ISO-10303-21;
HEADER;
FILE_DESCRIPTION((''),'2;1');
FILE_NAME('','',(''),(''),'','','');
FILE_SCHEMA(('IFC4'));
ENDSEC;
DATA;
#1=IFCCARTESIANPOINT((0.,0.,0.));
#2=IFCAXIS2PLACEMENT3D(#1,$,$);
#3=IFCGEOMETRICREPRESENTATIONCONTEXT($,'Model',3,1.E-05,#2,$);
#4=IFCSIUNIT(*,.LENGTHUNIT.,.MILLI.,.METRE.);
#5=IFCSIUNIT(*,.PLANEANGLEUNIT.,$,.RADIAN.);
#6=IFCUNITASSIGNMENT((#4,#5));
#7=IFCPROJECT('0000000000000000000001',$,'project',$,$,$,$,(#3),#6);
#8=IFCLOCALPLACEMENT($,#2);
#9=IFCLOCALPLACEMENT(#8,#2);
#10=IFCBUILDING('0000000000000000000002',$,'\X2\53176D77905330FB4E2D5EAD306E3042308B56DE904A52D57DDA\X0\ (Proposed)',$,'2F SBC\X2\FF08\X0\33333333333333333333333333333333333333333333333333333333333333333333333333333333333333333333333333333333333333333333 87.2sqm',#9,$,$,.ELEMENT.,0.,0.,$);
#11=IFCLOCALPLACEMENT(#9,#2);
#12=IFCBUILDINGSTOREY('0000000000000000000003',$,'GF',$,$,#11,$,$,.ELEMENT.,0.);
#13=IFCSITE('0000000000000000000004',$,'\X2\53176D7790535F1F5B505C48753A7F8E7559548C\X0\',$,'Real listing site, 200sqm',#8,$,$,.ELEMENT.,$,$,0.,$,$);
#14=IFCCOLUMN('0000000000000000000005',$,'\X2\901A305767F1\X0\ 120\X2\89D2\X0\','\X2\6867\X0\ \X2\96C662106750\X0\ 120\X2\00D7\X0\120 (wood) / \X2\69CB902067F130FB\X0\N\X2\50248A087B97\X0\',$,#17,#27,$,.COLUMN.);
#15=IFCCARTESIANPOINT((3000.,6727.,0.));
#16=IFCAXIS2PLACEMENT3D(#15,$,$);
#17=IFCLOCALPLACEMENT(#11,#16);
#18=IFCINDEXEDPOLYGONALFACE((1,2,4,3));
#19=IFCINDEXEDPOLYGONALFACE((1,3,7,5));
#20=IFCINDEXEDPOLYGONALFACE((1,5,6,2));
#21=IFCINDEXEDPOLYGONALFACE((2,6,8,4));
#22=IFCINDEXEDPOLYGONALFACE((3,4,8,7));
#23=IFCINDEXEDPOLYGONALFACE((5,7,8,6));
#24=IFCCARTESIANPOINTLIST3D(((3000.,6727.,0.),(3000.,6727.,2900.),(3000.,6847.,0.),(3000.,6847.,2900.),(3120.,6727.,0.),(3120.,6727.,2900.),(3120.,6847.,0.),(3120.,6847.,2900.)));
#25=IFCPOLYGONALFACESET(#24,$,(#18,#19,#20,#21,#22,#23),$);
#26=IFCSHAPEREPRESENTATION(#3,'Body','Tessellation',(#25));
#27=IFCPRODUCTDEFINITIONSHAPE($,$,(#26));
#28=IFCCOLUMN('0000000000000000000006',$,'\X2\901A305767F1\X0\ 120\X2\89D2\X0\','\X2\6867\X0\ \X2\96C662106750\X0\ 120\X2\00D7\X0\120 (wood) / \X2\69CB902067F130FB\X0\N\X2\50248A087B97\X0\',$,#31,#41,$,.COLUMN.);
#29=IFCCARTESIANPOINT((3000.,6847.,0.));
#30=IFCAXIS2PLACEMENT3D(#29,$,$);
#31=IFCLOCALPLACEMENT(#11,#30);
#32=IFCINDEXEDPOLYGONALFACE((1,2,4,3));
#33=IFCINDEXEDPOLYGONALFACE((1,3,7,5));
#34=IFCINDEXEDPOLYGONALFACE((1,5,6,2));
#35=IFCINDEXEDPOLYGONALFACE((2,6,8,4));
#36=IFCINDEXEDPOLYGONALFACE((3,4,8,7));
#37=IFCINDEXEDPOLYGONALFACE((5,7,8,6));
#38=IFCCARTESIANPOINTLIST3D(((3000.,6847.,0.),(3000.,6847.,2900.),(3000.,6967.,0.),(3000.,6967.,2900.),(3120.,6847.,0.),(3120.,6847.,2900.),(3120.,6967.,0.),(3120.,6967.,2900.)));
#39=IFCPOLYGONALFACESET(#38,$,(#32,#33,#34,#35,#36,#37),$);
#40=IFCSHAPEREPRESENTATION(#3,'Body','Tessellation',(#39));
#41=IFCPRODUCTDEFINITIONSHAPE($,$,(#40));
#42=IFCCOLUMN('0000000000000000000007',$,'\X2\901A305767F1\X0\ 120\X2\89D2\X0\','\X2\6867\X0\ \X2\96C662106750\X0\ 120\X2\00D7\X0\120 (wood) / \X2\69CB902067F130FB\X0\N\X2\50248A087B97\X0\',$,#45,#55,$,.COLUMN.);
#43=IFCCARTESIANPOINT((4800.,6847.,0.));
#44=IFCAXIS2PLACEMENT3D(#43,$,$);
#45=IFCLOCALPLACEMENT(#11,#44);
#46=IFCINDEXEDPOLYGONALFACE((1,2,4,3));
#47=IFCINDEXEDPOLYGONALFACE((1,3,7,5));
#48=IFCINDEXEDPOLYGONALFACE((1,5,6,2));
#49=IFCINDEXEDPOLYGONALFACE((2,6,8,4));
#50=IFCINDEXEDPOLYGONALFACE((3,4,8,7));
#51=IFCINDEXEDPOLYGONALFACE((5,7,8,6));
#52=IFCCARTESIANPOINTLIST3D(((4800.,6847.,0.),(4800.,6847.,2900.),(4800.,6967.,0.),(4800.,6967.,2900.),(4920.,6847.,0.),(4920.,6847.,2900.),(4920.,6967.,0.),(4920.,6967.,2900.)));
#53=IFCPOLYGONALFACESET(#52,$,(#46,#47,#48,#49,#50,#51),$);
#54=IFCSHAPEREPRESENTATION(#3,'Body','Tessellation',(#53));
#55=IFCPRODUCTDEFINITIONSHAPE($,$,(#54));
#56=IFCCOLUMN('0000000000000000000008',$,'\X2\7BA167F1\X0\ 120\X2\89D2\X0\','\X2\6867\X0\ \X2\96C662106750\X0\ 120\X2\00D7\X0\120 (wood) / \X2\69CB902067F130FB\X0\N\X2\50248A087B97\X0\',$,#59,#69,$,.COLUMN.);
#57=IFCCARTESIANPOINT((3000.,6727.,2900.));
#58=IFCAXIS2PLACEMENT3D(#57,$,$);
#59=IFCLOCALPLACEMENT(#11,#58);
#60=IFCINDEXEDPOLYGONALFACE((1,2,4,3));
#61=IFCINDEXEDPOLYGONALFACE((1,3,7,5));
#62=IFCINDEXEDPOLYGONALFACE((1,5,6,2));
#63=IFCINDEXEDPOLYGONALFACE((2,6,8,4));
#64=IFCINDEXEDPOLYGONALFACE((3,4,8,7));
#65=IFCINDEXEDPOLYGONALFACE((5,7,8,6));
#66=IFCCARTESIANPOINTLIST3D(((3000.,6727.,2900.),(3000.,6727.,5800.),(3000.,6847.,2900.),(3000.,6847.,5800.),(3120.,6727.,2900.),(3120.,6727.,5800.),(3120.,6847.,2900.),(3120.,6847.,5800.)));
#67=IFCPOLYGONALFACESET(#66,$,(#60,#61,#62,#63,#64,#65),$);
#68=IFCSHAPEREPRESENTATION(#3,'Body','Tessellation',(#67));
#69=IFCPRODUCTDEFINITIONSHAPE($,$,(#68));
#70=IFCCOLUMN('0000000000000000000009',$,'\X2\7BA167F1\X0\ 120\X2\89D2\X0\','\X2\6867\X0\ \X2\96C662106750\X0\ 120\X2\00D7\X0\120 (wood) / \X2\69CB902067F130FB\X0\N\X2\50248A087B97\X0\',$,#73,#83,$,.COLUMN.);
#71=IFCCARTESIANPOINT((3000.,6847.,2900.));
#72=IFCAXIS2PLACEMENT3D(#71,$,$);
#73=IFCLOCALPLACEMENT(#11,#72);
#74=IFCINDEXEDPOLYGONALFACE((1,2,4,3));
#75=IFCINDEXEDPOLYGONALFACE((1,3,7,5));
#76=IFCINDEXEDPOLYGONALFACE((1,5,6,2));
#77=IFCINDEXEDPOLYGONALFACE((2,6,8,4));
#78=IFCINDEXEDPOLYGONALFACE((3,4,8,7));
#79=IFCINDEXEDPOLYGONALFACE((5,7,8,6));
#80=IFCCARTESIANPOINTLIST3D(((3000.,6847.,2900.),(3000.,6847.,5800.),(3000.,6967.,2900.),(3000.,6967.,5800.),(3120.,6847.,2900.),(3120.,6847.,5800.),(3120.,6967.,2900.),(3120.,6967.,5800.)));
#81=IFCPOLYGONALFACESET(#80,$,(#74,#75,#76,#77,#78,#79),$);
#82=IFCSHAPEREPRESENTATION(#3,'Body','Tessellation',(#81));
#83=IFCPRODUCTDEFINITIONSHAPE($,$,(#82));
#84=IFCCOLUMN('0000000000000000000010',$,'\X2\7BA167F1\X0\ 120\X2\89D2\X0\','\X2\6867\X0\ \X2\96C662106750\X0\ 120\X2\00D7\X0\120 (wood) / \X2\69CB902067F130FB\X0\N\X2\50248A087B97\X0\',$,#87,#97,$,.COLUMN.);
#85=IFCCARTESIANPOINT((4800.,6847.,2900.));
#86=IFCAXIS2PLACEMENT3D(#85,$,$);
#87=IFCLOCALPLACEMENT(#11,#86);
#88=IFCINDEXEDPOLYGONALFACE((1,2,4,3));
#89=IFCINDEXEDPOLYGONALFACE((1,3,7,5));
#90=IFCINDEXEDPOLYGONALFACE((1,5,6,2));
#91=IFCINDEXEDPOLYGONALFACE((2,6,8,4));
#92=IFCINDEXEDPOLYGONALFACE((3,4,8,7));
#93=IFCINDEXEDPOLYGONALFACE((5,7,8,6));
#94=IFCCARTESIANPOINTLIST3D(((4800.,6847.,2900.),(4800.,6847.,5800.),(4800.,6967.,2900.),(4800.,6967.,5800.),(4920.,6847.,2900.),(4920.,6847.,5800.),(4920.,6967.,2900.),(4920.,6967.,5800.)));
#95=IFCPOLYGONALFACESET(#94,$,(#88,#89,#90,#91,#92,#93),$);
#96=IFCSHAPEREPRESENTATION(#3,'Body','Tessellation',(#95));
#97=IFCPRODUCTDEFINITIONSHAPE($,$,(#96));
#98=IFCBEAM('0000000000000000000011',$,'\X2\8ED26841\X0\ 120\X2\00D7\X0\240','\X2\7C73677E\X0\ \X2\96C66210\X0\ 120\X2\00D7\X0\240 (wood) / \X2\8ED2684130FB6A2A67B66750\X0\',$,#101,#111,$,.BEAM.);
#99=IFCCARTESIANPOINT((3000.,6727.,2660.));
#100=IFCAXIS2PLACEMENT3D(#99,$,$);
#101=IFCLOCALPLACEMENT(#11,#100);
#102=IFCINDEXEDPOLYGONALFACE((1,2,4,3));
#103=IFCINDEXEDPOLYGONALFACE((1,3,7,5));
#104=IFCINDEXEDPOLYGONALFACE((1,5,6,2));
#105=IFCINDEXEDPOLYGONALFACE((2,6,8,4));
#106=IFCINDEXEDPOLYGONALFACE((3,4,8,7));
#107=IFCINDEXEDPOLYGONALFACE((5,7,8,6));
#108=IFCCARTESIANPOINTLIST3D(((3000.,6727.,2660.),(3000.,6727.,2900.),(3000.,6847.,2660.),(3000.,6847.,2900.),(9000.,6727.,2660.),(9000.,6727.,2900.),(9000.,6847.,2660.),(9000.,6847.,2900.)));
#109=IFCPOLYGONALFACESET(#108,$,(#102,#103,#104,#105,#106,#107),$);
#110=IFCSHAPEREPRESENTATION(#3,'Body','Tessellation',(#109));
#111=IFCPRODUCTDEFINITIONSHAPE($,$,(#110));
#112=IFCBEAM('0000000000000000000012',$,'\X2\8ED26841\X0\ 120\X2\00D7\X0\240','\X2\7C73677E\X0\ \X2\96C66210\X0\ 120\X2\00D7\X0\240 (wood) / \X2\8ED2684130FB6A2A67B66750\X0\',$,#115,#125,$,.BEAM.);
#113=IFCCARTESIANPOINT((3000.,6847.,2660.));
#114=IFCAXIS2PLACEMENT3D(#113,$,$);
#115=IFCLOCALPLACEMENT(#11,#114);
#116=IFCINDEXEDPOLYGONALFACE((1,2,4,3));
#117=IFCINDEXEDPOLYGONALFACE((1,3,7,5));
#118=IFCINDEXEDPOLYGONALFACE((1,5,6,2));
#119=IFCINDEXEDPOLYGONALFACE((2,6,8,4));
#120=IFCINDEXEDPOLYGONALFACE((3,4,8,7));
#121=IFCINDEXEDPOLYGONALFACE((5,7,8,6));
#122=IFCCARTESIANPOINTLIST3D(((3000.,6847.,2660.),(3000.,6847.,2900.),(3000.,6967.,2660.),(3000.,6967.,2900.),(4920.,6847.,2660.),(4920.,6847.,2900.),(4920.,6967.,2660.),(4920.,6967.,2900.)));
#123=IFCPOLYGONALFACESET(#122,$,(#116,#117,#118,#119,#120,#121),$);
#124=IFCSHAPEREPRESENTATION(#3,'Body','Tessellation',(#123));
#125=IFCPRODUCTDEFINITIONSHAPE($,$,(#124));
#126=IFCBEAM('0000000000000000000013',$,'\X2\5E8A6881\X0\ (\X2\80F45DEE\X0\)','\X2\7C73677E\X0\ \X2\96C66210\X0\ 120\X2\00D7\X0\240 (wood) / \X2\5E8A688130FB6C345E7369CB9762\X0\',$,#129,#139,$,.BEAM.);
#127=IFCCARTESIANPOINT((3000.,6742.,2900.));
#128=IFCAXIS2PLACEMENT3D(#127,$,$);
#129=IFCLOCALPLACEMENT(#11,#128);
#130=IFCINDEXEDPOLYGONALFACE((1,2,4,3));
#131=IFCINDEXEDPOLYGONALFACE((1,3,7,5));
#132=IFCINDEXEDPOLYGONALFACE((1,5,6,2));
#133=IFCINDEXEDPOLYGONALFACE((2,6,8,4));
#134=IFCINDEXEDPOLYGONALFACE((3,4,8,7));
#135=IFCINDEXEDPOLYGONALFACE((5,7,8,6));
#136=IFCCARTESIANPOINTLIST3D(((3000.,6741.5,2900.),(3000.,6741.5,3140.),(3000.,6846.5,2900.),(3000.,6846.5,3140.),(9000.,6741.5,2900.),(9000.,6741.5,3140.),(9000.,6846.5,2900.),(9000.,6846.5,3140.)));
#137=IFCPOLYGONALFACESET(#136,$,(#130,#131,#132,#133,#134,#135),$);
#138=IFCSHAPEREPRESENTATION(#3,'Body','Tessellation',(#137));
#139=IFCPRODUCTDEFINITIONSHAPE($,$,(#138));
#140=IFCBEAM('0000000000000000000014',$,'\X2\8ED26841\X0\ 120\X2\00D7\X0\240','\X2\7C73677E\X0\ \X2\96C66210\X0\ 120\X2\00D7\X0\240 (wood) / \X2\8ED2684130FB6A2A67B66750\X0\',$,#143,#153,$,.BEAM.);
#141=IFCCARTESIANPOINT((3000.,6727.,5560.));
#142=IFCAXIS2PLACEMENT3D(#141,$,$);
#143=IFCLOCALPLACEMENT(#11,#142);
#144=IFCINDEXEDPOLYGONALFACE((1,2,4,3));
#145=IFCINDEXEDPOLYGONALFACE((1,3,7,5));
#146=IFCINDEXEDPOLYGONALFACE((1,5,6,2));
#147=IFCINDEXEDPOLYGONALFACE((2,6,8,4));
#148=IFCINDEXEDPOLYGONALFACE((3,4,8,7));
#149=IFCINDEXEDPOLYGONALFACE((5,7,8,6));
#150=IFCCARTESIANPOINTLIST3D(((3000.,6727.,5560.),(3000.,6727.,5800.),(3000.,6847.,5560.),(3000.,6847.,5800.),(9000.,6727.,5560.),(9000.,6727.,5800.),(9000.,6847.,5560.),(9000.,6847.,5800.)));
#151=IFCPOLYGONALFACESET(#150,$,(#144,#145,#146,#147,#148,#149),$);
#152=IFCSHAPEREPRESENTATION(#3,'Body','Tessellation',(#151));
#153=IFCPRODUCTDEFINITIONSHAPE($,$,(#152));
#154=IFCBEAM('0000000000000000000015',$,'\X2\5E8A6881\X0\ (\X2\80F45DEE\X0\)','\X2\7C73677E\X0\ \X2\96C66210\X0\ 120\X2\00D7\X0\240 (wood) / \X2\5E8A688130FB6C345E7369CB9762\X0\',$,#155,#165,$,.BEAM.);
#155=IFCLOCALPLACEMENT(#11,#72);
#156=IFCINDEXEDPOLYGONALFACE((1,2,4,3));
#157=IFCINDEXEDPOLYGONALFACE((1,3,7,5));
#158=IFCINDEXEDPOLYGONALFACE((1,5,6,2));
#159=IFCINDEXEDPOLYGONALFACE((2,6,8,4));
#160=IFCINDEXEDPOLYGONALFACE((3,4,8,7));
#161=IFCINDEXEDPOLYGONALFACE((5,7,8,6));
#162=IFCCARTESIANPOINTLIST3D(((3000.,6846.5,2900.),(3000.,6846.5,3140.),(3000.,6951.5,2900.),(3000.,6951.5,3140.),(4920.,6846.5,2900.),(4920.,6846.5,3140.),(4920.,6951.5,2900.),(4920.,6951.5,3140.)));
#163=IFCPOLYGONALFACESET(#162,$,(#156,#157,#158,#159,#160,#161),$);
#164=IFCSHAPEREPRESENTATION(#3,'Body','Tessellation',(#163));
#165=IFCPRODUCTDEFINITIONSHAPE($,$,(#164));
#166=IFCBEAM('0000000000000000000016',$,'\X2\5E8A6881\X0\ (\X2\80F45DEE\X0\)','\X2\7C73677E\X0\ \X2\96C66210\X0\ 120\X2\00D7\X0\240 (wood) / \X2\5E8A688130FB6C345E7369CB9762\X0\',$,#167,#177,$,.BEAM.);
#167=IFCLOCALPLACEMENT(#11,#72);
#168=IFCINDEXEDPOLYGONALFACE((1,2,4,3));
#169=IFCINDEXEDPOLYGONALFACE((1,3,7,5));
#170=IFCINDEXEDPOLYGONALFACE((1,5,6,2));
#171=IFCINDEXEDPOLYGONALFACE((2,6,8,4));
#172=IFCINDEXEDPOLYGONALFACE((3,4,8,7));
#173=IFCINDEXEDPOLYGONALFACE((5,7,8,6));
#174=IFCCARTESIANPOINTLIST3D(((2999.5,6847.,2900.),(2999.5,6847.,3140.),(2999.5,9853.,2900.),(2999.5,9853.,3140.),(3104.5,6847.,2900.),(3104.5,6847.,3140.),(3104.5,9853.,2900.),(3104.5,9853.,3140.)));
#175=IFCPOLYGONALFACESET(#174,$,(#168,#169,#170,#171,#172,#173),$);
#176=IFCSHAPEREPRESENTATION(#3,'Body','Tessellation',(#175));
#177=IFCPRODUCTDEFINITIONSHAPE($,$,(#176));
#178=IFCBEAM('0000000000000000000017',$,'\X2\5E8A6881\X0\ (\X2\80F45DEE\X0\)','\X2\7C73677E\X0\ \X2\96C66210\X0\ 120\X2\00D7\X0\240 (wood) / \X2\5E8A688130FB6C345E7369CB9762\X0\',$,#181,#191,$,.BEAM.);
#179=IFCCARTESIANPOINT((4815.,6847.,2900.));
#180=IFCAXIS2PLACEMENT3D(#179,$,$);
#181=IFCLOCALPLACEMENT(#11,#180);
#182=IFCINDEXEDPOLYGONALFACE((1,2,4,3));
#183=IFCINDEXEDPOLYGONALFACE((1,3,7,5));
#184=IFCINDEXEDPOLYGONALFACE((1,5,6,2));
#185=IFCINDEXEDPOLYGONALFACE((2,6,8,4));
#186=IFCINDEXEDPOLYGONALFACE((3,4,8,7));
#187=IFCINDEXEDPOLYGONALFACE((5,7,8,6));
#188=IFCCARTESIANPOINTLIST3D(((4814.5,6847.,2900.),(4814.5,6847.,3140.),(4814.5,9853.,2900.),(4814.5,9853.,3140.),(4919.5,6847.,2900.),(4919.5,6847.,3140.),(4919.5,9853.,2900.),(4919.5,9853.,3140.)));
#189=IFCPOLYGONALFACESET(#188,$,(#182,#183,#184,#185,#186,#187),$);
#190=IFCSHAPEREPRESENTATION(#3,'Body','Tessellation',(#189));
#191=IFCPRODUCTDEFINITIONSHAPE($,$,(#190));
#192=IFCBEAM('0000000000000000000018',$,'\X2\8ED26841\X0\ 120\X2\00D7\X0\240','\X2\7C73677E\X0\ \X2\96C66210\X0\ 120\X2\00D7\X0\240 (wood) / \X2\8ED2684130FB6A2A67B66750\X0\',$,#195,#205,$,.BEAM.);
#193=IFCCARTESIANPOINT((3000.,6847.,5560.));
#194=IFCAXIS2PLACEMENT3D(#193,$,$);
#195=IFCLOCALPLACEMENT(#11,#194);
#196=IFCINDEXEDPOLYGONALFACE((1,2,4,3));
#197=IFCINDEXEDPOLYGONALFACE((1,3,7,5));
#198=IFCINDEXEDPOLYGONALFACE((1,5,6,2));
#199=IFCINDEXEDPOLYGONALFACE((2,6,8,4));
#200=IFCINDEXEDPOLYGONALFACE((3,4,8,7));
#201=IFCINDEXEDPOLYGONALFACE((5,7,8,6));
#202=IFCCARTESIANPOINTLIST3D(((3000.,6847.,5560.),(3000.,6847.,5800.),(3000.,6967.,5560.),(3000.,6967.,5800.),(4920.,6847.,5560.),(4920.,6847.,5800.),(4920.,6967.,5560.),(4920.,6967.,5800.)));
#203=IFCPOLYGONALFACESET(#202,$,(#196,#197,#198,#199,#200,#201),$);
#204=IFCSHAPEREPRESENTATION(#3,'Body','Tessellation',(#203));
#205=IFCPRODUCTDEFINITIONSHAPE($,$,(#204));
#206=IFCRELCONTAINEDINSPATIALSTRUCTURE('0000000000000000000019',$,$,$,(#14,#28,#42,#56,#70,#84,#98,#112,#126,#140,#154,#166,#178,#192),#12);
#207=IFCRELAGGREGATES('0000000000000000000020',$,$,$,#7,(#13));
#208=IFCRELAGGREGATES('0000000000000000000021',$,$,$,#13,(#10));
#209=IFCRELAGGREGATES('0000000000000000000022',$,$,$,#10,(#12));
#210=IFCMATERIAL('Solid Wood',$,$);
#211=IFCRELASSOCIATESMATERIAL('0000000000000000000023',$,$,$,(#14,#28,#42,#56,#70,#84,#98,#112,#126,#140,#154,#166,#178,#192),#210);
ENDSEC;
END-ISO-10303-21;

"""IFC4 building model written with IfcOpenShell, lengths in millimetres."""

from ifc_helpers import new_model, si_unit, frame, frame_2d, origin, place, context, project, spatial, rectangle, extrude, material, element, save


model = new_model("IFC4")

# Units and contexts
model_context = context("Model", 3, precision=1e-05, world=origin())
ifc_project = project(units=[si_unit("LENGTHUNIT", "METRE", prefix="MILLI"), si_unit("PLANEANGLEUNIT", "RADIAN")], contexts=[model_context])

# Site, building, storey
site_placement = place(None, origin())
site = spatial("IfcSite", under=ifc_project, at=site_placement, Name="北海道弟子屈町美留和", ObjectType="Real listing site, 200sqm", CompositionType="ELEMENT", RefElevation=0.0)
building_placement = place(site_placement, origin())
building = spatial("IfcBuilding", under=site, at=building_placement, Name="北海道・中庭のある回遊動線 (Proposed)", ObjectType="2F SBC（33333333333333333333333333333333333333333333333333333333333333333333333333333333333333333333333333333333333333333333 87.2sqm", CompositionType="ELEMENT", ElevationOfRefHeight=0.0, ElevationOfTerrain=0.0)
storey_placement = place(building_placement, origin())
storey = spatial("IfcBuildingStorey", under=building, at=storey_placement, Name="GF", CompositionType="ELEMENT", Elevation=0.0)

# Columns
ifc_material_1 = material(Name="Solid Wood")
column_1_placement = place(storey_placement, frame((3000.0, 6727.0, 0.0)))
element("IfcColumn", 1, at=column_1_placement, inside=storey, material=ifc_material_1, Name="通し柱 120角", Description="桧 集成材 120×120 (wood) / 構造柱・N値計算", PredefinedType="COLUMN", context=model_context, shape_type="SweptSolid", body=[
    extrude(rectangle(XDim=120.0, YDim=120.0, at=frame_2d((60.0, 60.0))), frame((3000.0, 6727.0, 0.0)), (0.0, 0.0, 1.0), 2900.0),
])
column_2_placement = place(storey_placement, frame((3000.0, 6847.0, 0.0)))
element("IfcColumn", 2, at=column_2_placement, inside=storey, material=ifc_material_1, Name="通し柱 120角", Description="桧 集成材 120×120 (wood) / 構造柱・N値計算", PredefinedType="COLUMN", context=model_context, shape_type="SweptSolid", body=[
    extrude(rectangle(XDim=120.0, YDim=120.0, at=frame_2d((60.0, 60.0))), frame((3000.0, 6847.0, 0.0)), (0.0, 0.0, 1.0), 2900.0),
])
column_3_placement = place(storey_placement, frame((4800.0, 6847.0, 0.0)))
element("IfcColumn", 3, at=column_3_placement, inside=storey, material=ifc_material_1, Name="通し柱 120角", Description="桧 集成材 120×120 (wood) / 構造柱・N値計算", PredefinedType="COLUMN", context=model_context, shape_type="SweptSolid", body=[
    extrude(rectangle(XDim=120.0, YDim=120.0, at=frame_2d((60.0, 60.0))), frame((4800.0, 6847.0, 0.0)), (0.0, 0.0, 1.0), 2900.0),
])
column_4_placement = place(storey_placement, frame((3000.0, 6727.0, 2900.0)))
element("IfcColumn", 4, at=column_4_placement, inside=storey, material=ifc_material_1, Name="管柱 120角", Description="桧 集成材 120×120 (wood) / 構造柱・N値計算", PredefinedType="COLUMN", context=model_context, shape_type="SweptSolid", body=[
    extrude(rectangle(XDim=120.0, YDim=120.0, at=frame_2d((60.0, 60.0))), frame((3000.0, 6727.0, 2900.0)), (0.0, 0.0, 1.0), 2900.0),
])
column_5_placement = place(storey_placement, frame((3000.0, 6847.0, 2900.0)))
element("IfcColumn", 5, at=column_5_placement, inside=storey, material=ifc_material_1, Name="管柱 120角", Description="桧 集成材 120×120 (wood) / 構造柱・N値計算", PredefinedType="COLUMN", context=model_context, shape_type="SweptSolid", body=[
    extrude(rectangle(XDim=120.0, YDim=120.0, at=frame_2d((60.0, 60.0))), frame((3000.0, 6847.0, 2900.0)), (0.0, 0.0, 1.0), 2900.0),
])
column_6_placement = place(storey_placement, frame((4800.0, 6847.0, 2900.0)))
element("IfcColumn", 6, at=column_6_placement, inside=storey, material=ifc_material_1, Name="管柱 120角", Description="桧 集成材 120×120 (wood) / 構造柱・N値計算", PredefinedType="COLUMN", context=model_context, shape_type="SweptSolid", body=[
    extrude(rectangle(XDim=120.0, YDim=120.0, at=frame_2d((60.0, 60.0))), frame((4800.0, 6847.0, 2900.0)), (0.0, 0.0, 1.0), 2900.0),
])

# Beams
beam_1_placement = place(storey_placement, frame((3000.0, 6727.0, 2660.0)))
element("IfcBeam", 7, at=beam_1_placement, inside=storey, material=ifc_material_1, Name="軒桁 120×240", Description="米松 集成 120×240 (wood) / 軒桁・横架材", PredefinedType="BEAM", context=model_context, shape_type="SweptSolid", body=[
    extrude(rectangle(XDim=6000.0, YDim=120.0, at=frame_2d((3000.0, 60.0))), frame((3000.0, 6727.0, 2660.0)), (0.0, 0.0, 1.0), 240.0),
])
beam_2_placement = place(storey_placement, frame((3000.0, 6847.0, 2660.0)))
element("IfcBeam", 8, at=beam_2_placement, inside=storey, material=ifc_material_1, Name="軒桁 120×240", Description="米松 集成 120×240 (wood) / 軒桁・横架材", PredefinedType="BEAM", context=model_context, shape_type="SweptSolid", body=[
    extrude(rectangle(XDim=1920.0, YDim=120.0, at=frame_2d((960.0, 60.0))), frame((3000.0, 6847.0, 2660.0)), (0.0, 0.0, 1.0), 240.0),
])
beam_3_placement = place(storey_placement, frame((3000.0, 6742.0, 2900.0)))
element("IfcBeam", 9, at=beam_3_placement, inside=storey, material=ifc_material_1, Name="床梁 (胴差)", Description="米松 集成 120×240 (wood) / 床梁・水平構面", PredefinedType="BEAM", context=model_context, shape_type="SweptSolid", body=[
    extrude(rectangle(XDim=6000.0, YDim=105.0, at=frame_2d((3000.0, 52.0))), frame((3000.0, 6742.0, 2900.0)), (0.0, 0.0, 1.0), 240.0),
])
beam_4_placement = place(storey_placement, frame((3000.0, 6727.0, 5560.0)))
element("IfcBeam", 10, at=beam_4_placement, inside=storey, material=ifc_material_1, Name="軒桁 120×240", Description="米松 集成 120×240 (wood) / 軒桁・横架材", PredefinedType="BEAM", context=model_context, shape_type="SweptSolid", body=[
    extrude(rectangle(XDim=6000.0, YDim=120.0, at=frame_2d((3000.0, 60.0))), frame((3000.0, 6727.0, 5560.0)), (0.0, 0.0, 1.0), 240.0),
])
beam_5_placement = place(storey_placement, frame((3000.0, 6847.0, 2900.0)))
element("IfcBeam", 11, at=beam_5_placement, inside=storey, material=ifc_material_1, Name="床梁 (胴差)", Description="米松 集成 120×240 (wood) / 床梁・水平構面", PredefinedType="BEAM", context=model_context, shape_type="SweptSolid", body=[
    extrude(rectangle(XDim=1920.0, YDim=105.0, at=frame_2d((960.0, 52.0))), frame((3000.0, 6847.0, 2900.0)), (0.0, 0.0, 1.0), 240.0),
])
beam_6_placement = place(storey_placement, frame((3000.0, 6847.0, 2900.0)))
element("IfcBeam", 12, at=beam_6_placement, inside=storey, material=ifc_material_1, Name="床梁 (胴差)", Description="米松 集成 120×240 (wood) / 床梁・水平構面", PredefinedType="BEAM", context=model_context, shape_type="SweptSolid", body=[
    extrude(rectangle(XDim=105.0, YDim=3006.0, at=frame_2d((52.0, 1503.0))), frame((3000.0, 6847.0, 2900.0)), (0.0, 0.0, 1.0), 240.0),
])
beam_7_placement = place(storey_placement, frame((4815.0, 6847.0, 2900.0)))
element("IfcBeam", 13, at=beam_7_placement, inside=storey, material=ifc_material_1, Name="床梁 (胴差)", Description="米松 集成 120×240 (wood) / 床梁・水平構面", PredefinedType="BEAM", context=model_context, shape_type="SweptSolid", body=[
    extrude(rectangle(XDim=105.0, YDim=3006.0, at=frame_2d((52.0, 1503.0))), frame((4815.0, 6847.0, 2900.0)), (0.0, 0.0, 1.0), 240.0),
])
beam_8_placement = place(storey_placement, frame((3000.0, 6847.0, 5560.0)))
element("IfcBeam", 14, at=beam_8_placement, inside=storey, material=ifc_material_1, Name="軒桁 120×240", Description="米松 集成 120×240 (wood) / 軒桁・横架材", PredefinedType="BEAM", context=model_context, shape_type="SweptSolid", body=[
    extrude(rectangle(XDim=1920.0, YDim=120.0, at=frame_2d((960.0, 60.0))), frame((3000.0, 6847.0, 5560.0)), (0.0, 0.0, 1.0), 240.0),
])

save(model, "model.ifc")
